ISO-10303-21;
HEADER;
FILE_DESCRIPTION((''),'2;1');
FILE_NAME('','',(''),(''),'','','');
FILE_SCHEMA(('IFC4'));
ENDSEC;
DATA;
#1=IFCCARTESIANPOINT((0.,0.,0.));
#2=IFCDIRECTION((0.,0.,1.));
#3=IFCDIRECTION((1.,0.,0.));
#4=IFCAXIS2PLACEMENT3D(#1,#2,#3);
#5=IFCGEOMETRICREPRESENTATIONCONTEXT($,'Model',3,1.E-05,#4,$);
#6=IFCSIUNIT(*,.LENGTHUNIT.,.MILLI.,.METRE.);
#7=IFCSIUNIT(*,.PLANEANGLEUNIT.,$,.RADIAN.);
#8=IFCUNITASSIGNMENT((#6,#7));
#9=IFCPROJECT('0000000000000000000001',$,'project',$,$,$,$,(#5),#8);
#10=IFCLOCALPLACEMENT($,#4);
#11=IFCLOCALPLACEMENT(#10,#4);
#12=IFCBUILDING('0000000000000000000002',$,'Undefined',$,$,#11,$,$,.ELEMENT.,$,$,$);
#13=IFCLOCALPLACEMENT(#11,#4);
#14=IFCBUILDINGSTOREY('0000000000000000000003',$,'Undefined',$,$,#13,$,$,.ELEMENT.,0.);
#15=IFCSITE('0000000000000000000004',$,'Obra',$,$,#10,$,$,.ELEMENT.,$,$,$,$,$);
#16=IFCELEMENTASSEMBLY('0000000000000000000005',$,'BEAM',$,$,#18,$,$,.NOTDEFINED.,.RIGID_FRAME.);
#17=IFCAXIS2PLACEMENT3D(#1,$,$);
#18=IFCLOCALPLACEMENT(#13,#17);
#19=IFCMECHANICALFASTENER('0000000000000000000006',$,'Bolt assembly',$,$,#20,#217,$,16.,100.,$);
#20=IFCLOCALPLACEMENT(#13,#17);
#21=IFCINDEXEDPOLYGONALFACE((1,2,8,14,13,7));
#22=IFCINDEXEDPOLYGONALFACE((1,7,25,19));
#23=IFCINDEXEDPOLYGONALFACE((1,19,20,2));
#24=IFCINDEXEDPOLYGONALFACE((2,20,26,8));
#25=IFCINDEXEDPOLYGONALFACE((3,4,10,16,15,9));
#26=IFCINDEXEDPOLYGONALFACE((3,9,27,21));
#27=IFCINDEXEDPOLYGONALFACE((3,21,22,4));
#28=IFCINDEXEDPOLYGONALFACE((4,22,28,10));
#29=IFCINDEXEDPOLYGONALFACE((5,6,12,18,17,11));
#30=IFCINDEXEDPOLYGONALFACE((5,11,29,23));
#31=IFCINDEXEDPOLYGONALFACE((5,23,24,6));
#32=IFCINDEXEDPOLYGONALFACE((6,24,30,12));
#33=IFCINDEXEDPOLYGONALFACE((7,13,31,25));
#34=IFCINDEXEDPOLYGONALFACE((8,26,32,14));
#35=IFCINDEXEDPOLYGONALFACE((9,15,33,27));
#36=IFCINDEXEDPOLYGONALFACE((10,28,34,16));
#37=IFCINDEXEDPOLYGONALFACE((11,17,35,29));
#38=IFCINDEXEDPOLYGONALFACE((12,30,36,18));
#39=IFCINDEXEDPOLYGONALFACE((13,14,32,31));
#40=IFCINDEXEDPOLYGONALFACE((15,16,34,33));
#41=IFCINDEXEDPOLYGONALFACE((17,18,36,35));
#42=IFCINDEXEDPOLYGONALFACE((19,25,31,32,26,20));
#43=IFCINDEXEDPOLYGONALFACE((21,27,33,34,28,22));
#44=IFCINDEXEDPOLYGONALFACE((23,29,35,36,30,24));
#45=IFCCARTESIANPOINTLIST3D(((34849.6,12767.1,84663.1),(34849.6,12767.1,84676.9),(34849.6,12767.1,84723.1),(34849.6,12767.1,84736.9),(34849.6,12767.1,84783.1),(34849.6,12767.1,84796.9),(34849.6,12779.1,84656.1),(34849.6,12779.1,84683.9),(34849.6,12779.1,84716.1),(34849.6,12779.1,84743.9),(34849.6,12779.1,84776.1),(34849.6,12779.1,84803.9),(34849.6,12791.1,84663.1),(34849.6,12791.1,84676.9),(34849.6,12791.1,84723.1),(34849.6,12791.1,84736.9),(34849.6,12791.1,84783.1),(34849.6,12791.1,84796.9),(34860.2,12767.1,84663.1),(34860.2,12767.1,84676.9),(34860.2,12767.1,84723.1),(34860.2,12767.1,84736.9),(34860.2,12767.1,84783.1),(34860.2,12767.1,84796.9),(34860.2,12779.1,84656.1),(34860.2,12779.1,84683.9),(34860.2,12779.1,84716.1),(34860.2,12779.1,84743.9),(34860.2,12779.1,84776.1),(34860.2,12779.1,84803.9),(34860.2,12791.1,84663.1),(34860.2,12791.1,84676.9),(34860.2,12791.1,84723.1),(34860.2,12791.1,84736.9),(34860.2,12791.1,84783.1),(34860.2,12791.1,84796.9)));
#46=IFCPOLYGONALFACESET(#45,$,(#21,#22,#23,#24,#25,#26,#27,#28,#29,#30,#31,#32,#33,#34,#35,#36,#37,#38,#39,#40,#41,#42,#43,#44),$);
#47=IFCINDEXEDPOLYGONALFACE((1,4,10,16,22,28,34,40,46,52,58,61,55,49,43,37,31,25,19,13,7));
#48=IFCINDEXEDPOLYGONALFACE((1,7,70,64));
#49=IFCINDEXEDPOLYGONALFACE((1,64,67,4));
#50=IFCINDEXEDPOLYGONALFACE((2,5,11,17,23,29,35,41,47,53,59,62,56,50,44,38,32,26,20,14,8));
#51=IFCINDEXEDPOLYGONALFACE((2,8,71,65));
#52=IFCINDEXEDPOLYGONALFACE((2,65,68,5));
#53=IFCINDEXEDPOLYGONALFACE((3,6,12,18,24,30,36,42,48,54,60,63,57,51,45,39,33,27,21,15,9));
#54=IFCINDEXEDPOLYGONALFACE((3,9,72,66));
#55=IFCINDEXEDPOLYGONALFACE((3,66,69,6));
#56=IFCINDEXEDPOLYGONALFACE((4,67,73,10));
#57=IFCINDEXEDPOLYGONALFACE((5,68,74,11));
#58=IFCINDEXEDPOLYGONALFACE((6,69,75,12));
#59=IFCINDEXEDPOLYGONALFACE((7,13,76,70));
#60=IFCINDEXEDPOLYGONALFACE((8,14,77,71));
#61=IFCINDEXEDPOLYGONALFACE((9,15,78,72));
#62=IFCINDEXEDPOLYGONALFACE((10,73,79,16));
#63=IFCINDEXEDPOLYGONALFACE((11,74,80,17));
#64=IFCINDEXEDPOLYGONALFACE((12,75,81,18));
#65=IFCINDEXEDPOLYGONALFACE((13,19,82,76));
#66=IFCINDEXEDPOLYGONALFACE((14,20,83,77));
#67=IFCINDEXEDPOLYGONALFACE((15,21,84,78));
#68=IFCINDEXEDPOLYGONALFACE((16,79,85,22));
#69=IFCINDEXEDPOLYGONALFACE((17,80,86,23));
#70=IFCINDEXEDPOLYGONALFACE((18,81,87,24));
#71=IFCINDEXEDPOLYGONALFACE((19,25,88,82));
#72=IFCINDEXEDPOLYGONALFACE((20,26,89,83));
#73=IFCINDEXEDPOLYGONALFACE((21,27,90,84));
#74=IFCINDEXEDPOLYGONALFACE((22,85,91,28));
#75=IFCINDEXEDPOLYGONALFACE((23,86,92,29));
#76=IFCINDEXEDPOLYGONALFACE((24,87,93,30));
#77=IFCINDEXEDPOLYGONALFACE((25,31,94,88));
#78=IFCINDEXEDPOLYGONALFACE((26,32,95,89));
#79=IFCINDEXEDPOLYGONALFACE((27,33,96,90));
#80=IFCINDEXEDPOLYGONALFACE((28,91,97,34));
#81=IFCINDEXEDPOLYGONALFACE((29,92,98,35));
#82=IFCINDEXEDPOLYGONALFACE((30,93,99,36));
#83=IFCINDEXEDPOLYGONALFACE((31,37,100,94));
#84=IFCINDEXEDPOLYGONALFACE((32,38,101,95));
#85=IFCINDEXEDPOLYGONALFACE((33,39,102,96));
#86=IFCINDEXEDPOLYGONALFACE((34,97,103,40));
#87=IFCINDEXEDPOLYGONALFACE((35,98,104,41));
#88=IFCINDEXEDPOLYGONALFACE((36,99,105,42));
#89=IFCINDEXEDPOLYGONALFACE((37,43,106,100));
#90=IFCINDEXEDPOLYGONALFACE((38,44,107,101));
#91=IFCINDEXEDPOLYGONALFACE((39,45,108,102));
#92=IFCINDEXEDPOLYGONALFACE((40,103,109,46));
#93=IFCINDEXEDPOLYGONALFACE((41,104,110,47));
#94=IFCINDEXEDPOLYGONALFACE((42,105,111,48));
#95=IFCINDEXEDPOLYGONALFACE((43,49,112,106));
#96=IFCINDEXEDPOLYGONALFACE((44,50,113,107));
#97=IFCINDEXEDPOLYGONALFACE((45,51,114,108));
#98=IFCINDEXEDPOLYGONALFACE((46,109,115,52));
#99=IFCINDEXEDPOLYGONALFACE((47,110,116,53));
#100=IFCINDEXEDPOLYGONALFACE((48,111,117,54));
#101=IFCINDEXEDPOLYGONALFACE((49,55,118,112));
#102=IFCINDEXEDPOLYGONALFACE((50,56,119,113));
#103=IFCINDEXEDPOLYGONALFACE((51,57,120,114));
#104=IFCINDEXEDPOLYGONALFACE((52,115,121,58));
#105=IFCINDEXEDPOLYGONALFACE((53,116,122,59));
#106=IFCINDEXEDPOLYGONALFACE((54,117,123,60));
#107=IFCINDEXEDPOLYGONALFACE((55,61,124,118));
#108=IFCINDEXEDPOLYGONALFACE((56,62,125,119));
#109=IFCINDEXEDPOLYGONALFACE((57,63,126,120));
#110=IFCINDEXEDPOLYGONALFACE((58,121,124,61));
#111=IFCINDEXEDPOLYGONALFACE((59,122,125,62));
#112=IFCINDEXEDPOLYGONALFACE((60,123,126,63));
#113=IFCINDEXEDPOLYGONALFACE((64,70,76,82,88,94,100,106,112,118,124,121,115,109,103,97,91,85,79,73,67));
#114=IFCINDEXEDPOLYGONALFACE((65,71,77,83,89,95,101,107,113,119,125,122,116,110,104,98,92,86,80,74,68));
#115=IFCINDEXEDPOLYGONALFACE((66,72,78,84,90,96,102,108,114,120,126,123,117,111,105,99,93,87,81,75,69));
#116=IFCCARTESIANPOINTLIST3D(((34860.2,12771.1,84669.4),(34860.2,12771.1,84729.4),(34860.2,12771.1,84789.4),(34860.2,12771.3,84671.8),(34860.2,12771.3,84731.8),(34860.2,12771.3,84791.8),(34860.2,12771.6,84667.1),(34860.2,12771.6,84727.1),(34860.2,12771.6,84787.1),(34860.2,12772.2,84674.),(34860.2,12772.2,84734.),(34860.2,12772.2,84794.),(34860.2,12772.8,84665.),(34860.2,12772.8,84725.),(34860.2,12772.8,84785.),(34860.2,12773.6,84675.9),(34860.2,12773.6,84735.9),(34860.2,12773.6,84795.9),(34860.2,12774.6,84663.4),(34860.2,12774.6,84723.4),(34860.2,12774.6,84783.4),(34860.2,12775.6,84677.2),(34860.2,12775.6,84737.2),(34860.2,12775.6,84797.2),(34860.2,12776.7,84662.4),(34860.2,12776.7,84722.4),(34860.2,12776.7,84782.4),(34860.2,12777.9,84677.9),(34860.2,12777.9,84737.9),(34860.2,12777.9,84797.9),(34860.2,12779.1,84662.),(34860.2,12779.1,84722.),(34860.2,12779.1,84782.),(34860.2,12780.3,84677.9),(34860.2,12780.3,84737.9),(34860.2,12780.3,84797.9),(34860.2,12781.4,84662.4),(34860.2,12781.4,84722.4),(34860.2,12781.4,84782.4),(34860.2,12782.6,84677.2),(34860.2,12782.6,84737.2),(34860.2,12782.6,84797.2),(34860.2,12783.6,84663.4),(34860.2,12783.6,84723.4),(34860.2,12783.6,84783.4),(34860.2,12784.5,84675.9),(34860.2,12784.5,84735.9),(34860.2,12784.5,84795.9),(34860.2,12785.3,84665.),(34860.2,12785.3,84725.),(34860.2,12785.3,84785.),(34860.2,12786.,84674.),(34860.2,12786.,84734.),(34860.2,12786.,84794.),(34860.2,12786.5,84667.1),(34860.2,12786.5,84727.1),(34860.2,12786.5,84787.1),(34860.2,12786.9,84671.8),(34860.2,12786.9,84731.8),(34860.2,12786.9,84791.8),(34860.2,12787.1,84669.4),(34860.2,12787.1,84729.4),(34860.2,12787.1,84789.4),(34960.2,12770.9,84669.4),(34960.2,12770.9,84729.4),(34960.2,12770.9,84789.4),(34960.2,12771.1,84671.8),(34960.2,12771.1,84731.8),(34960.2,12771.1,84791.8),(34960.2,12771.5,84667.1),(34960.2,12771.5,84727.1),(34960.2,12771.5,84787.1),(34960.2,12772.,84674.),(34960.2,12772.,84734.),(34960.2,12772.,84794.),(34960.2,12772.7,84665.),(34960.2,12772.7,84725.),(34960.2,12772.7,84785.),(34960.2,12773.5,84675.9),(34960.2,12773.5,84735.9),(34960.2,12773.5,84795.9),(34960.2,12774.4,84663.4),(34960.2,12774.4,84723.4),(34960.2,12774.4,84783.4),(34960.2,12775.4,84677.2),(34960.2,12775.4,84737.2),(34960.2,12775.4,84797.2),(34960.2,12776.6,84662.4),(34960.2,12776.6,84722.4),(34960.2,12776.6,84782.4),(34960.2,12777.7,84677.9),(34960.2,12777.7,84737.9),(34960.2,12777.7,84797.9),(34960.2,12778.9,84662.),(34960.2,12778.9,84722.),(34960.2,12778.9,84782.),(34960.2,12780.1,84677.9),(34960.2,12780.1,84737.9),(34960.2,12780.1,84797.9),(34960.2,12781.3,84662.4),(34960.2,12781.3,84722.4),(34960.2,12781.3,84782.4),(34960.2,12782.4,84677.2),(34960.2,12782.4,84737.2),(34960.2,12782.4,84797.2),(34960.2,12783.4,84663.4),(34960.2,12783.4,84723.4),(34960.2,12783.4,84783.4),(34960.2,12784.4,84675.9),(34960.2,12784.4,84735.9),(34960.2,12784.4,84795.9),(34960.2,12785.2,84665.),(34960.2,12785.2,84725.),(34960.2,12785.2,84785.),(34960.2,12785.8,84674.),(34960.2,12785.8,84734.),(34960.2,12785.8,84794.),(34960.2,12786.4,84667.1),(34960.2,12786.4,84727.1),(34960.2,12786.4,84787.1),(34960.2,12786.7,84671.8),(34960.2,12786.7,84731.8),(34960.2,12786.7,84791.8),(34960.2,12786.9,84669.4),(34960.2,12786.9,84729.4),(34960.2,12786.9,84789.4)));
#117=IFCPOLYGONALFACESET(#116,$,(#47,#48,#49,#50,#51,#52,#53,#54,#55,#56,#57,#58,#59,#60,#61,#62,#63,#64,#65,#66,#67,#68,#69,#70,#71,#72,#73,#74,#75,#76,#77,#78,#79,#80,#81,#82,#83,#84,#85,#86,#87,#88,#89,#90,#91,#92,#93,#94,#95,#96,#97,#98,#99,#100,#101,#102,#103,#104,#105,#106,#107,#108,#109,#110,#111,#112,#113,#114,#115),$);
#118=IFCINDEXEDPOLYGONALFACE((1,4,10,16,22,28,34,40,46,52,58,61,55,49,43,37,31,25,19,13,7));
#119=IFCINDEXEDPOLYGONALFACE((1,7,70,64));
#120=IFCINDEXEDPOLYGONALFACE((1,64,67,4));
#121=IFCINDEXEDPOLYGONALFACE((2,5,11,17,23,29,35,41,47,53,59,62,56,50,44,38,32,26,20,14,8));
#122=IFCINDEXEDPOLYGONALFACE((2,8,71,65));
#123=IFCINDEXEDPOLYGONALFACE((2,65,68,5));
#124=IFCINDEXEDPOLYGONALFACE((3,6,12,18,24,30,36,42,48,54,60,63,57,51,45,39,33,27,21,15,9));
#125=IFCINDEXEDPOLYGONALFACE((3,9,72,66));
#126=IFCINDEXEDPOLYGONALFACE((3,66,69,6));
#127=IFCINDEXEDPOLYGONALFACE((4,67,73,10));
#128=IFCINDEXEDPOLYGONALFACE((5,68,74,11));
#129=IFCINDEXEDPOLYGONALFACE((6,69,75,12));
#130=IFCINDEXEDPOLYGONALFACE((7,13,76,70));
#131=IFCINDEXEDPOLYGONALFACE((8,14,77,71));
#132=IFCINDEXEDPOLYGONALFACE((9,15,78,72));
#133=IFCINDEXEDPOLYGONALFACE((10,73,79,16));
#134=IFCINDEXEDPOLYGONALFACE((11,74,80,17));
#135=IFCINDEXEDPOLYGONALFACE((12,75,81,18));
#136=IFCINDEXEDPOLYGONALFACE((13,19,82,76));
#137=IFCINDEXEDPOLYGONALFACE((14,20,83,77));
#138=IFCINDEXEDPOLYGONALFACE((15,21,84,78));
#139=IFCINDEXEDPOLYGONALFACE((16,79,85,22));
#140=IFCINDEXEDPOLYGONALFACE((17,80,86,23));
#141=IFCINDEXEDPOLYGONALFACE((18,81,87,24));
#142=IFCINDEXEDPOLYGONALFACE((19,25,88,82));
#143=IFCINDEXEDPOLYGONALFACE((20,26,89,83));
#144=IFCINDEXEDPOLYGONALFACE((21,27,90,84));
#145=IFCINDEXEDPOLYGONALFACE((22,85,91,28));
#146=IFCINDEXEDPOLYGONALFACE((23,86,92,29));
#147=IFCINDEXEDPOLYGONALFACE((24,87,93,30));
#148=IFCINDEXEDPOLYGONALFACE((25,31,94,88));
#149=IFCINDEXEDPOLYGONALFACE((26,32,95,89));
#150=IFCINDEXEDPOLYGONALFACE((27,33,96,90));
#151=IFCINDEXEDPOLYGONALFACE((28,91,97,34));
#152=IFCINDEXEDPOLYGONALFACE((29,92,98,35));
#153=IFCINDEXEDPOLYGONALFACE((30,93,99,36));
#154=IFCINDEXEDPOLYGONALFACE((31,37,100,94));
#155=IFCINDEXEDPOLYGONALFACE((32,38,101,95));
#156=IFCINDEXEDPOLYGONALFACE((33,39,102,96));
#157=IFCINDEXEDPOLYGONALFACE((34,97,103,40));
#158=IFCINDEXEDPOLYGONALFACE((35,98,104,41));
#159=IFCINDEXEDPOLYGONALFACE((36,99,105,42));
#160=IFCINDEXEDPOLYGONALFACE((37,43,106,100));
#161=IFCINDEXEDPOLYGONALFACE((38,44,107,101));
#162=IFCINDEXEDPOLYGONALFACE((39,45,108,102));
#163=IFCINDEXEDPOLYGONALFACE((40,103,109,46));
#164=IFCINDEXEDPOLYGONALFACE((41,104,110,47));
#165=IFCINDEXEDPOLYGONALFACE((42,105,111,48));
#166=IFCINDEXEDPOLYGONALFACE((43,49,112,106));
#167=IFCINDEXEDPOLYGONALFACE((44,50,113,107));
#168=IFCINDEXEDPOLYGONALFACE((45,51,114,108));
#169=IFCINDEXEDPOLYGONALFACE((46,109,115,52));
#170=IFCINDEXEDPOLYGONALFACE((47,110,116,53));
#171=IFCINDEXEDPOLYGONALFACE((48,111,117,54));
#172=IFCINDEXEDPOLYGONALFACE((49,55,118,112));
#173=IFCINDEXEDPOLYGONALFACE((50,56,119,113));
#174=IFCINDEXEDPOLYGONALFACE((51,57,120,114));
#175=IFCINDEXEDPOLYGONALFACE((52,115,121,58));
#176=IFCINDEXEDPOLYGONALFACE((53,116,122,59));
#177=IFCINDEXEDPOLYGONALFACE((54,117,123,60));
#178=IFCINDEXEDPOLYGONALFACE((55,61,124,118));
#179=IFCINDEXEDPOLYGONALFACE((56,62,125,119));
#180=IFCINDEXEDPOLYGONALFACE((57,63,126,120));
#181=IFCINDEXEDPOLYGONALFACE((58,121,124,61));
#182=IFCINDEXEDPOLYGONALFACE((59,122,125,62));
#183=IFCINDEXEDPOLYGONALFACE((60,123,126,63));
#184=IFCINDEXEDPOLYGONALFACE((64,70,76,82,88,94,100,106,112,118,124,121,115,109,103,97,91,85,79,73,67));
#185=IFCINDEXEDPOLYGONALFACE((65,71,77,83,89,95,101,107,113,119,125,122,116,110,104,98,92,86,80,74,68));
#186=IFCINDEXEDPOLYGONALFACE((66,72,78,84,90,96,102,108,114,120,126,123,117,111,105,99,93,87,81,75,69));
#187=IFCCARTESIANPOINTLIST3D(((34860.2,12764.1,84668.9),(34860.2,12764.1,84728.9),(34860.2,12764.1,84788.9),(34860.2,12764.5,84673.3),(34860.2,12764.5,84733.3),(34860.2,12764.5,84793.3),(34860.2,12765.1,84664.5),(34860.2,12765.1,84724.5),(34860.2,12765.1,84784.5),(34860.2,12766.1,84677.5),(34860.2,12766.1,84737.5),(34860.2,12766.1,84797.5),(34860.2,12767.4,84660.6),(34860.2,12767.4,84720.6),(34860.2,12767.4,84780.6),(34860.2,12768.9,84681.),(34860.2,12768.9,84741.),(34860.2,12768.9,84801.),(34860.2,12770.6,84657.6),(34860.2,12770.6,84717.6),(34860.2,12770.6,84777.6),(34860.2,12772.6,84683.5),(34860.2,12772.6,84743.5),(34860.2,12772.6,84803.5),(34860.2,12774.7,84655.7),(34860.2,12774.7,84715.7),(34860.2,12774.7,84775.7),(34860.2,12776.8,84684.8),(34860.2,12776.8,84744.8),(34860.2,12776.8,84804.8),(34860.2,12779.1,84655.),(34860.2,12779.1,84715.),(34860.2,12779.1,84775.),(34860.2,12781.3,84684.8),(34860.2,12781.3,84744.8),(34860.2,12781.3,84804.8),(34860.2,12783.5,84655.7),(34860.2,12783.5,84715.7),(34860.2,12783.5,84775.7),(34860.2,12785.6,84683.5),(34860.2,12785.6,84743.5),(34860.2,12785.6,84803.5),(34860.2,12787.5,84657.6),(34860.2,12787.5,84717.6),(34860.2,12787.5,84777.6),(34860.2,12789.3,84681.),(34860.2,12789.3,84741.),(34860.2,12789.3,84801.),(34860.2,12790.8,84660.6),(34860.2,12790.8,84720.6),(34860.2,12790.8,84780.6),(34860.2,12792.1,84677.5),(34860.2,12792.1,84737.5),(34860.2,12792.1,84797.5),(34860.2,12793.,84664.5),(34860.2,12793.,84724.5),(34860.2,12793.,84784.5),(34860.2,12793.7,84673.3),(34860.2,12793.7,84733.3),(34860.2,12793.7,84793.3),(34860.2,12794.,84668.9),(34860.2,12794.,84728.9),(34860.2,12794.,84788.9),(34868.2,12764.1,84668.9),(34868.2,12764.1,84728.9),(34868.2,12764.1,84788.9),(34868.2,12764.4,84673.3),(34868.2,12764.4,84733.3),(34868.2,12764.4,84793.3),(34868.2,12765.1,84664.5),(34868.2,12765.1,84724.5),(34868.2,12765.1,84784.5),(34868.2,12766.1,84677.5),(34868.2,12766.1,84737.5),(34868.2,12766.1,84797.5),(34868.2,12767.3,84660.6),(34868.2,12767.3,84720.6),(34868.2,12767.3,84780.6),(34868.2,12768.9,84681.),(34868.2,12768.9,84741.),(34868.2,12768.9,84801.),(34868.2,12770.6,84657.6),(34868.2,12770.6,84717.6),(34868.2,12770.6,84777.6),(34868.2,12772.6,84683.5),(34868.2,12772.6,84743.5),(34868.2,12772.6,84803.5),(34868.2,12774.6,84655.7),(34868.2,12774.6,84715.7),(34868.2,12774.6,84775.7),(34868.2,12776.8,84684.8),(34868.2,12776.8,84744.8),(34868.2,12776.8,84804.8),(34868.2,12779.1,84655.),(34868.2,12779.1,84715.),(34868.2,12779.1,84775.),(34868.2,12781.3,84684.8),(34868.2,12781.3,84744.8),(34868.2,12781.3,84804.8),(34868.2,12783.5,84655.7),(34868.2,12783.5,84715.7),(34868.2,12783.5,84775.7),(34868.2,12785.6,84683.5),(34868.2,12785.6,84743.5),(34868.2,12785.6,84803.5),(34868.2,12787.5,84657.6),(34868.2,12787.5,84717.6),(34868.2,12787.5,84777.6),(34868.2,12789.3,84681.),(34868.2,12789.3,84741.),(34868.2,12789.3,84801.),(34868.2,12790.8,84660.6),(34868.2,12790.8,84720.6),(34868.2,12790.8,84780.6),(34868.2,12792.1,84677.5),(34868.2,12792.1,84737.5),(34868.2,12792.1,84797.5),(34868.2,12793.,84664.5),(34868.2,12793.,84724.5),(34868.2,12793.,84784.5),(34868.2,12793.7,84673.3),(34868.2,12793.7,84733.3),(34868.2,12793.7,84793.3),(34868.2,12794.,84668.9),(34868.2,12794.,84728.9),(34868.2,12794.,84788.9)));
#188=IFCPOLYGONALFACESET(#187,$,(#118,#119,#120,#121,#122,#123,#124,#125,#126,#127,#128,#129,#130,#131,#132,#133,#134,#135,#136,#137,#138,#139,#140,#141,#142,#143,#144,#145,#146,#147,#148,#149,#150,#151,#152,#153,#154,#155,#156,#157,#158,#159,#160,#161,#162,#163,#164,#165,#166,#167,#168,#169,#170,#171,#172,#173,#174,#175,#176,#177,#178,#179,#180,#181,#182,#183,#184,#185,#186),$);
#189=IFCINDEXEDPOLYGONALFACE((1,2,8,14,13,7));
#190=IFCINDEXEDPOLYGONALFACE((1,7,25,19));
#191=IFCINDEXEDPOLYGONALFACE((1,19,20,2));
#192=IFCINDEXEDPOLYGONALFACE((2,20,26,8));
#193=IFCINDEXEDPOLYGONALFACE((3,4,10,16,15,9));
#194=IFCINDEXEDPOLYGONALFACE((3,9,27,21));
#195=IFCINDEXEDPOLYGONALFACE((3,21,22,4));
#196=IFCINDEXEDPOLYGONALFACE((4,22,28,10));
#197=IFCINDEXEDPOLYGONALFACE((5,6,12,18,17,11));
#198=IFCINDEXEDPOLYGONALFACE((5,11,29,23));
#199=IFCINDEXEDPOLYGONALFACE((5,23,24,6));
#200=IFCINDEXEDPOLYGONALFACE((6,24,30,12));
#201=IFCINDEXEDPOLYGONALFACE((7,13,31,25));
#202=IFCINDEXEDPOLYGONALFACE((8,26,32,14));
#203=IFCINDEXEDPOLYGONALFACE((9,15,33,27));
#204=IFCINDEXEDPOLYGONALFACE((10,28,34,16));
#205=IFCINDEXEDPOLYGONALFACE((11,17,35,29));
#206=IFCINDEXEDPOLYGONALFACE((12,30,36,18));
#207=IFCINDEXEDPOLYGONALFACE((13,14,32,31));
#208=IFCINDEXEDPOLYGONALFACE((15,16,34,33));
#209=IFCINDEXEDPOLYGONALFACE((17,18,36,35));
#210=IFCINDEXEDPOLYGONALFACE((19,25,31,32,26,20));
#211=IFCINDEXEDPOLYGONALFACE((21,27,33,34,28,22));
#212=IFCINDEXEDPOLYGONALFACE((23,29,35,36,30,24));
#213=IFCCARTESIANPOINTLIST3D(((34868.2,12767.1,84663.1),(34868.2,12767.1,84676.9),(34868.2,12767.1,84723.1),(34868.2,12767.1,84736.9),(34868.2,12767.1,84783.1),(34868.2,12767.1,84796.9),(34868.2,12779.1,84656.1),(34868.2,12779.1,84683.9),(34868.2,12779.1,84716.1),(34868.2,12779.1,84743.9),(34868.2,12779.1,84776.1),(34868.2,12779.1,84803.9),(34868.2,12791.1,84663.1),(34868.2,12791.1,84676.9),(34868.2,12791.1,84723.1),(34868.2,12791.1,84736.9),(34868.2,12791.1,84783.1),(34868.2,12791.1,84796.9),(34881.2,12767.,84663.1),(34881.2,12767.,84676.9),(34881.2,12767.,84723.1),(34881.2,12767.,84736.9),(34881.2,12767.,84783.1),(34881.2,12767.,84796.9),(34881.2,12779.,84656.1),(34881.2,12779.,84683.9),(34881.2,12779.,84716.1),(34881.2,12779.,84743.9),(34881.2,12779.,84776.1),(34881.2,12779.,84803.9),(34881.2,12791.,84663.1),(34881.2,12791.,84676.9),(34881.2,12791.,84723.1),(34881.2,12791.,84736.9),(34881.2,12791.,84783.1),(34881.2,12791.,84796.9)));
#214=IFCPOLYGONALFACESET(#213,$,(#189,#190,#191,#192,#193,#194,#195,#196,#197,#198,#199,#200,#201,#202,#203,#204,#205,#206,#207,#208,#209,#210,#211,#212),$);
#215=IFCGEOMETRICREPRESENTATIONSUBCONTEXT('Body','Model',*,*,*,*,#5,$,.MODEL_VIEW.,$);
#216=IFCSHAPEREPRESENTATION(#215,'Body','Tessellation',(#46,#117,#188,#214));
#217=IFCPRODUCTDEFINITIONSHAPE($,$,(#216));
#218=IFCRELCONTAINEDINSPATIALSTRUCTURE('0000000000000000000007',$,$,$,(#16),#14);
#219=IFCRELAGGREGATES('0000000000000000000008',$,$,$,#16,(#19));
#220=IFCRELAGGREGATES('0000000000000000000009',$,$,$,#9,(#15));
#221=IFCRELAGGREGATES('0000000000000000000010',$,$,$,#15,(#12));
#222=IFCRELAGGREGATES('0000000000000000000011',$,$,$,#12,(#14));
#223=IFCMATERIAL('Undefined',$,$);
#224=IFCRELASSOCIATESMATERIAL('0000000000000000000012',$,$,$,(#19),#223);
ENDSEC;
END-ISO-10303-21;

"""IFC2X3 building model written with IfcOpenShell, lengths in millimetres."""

from ifc_helpers import new_model, si_unit, frame, origin_with_axes, origin_2d_with_axis, place, context, subcontext, project, spatial, polyline, circle, outline, extrude, source, transform, mapped, material, element, aggregate, save


model = new_model("IFC2X3")

# Units and contexts
model_context = context("Model", 3, precision=1e-05, world=origin_with_axes())
body_context = subcontext(model_context, "Body", "Model", "MODEL_VIEW")
ifc_project = project(units=[si_unit("LENGTHUNIT", "METRE", prefix="MILLI"), si_unit("PLANEANGLEUNIT", "RADIAN")], contexts=[model_context])

# Site, building, storey
site_placement = place(None, origin_with_axes())
site = spatial("IfcSite", under=ifc_project, at=site_placement, Name="Obra", CompositionType="ELEMENT")
building_placement = place(site_placement, origin_with_axes())
building = spatial("IfcBuilding", under=site, at=building_placement, Name="Undefined", CompositionType="ELEMENT")
storey_placement = place(building_placement, origin_with_axes())
storey = spatial("IfcBuildingStorey", under=building, at=storey_placement, Name="Undefined", CompositionType="ELEMENT", Elevation=0.0)

# Shared definitions
ifc_material_1 = material(Name="Undefined")

# Element assembly, mechanical fastener
assembly_1_placement = place(storey_placement, origin_with_axes())
assembly_1 = element("IfcElementAssembly", 1, at=assembly_1_placement, inside=storey, Name="BEAM", AssemblyPlace="NOTDEFINED", PredefinedType="RIGID_FRAME")
shared_shape_1 = source(origin_with_axes(), body_context, "Body", "SweptSolid", [
    extrude(outline(polyline([(13.9, 0.0), (6.9, 12.0), (-6.9, 12.0), (-13.9, 0.0), (-6.9, -12.0), (6.9, -12.0), (13.9, 0.0)])), frame((0.0, -10.6, 0.0), z_axis=(0.0, 1.0, 0.0), x_axis=(1.0, 0.0, 0.0)), (0.0, 0.0, 1.0), 10.6),
    extrude(circle(Radius=8.0, at=origin_2d_with_axis()), frame((0.0, 0.0, 0.0), z_axis=(0.0, 1.0, 0.0), x_axis=(1.0, 0.0, 0.0)), (0.0, 0.0, 1.0), 100.0),
    extrude(circle(Radius=15.0, at=origin_2d_with_axis()), frame((0.0, 0.0, 0.0), z_axis=(0.0, 1.0, 0.0), x_axis=(1.0, 0.0, 0.0)), (0.0, 0.0, 1.0), 8.0),
    extrude(outline(polyline([(13.9, 0.0), (6.9, 12.0), (-6.9, 12.0), (-13.9, 0.0), (-6.9, -12.0), (6.9, -12.0), (13.9, 0.0)])), frame((0.0, 8.0, 0.0), z_axis=(0.0, 1.0, 0.0), x_axis=(1.0, 0.0, 0.0)), (0.0, 0.0, 1.0), 13.0),
])
mechanical_fastener_1_placement = place(assembly_1_placement, frame((34860.3, 12829.1, 84850.0), z_axis=(-0.001625, -0.999999, 0.0), x_axis=(0.0, 0.0, -1.0)))
mechanical_fastener_1 = element("IfcMechanicalFastener", 2, at=mechanical_fastener_1_placement, material=ifc_material_1, Name="Bolt assembly", NominalDiameter=16.0, NominalLength=100.0, context=body_context, shape_type="MappedRepresentation", body=[
    mapped(shared_shape_1, transform((60.0, 0.0, 50.0))),
    mapped(shared_shape_1, transform((120.0, 0.0, 50.0))),
    mapped(shared_shape_1, transform((180.0, 0.0, 50.0))),
])
aggregate(assembly_1, [mechanical_fastener_1])

save(model, "model.ifc")
